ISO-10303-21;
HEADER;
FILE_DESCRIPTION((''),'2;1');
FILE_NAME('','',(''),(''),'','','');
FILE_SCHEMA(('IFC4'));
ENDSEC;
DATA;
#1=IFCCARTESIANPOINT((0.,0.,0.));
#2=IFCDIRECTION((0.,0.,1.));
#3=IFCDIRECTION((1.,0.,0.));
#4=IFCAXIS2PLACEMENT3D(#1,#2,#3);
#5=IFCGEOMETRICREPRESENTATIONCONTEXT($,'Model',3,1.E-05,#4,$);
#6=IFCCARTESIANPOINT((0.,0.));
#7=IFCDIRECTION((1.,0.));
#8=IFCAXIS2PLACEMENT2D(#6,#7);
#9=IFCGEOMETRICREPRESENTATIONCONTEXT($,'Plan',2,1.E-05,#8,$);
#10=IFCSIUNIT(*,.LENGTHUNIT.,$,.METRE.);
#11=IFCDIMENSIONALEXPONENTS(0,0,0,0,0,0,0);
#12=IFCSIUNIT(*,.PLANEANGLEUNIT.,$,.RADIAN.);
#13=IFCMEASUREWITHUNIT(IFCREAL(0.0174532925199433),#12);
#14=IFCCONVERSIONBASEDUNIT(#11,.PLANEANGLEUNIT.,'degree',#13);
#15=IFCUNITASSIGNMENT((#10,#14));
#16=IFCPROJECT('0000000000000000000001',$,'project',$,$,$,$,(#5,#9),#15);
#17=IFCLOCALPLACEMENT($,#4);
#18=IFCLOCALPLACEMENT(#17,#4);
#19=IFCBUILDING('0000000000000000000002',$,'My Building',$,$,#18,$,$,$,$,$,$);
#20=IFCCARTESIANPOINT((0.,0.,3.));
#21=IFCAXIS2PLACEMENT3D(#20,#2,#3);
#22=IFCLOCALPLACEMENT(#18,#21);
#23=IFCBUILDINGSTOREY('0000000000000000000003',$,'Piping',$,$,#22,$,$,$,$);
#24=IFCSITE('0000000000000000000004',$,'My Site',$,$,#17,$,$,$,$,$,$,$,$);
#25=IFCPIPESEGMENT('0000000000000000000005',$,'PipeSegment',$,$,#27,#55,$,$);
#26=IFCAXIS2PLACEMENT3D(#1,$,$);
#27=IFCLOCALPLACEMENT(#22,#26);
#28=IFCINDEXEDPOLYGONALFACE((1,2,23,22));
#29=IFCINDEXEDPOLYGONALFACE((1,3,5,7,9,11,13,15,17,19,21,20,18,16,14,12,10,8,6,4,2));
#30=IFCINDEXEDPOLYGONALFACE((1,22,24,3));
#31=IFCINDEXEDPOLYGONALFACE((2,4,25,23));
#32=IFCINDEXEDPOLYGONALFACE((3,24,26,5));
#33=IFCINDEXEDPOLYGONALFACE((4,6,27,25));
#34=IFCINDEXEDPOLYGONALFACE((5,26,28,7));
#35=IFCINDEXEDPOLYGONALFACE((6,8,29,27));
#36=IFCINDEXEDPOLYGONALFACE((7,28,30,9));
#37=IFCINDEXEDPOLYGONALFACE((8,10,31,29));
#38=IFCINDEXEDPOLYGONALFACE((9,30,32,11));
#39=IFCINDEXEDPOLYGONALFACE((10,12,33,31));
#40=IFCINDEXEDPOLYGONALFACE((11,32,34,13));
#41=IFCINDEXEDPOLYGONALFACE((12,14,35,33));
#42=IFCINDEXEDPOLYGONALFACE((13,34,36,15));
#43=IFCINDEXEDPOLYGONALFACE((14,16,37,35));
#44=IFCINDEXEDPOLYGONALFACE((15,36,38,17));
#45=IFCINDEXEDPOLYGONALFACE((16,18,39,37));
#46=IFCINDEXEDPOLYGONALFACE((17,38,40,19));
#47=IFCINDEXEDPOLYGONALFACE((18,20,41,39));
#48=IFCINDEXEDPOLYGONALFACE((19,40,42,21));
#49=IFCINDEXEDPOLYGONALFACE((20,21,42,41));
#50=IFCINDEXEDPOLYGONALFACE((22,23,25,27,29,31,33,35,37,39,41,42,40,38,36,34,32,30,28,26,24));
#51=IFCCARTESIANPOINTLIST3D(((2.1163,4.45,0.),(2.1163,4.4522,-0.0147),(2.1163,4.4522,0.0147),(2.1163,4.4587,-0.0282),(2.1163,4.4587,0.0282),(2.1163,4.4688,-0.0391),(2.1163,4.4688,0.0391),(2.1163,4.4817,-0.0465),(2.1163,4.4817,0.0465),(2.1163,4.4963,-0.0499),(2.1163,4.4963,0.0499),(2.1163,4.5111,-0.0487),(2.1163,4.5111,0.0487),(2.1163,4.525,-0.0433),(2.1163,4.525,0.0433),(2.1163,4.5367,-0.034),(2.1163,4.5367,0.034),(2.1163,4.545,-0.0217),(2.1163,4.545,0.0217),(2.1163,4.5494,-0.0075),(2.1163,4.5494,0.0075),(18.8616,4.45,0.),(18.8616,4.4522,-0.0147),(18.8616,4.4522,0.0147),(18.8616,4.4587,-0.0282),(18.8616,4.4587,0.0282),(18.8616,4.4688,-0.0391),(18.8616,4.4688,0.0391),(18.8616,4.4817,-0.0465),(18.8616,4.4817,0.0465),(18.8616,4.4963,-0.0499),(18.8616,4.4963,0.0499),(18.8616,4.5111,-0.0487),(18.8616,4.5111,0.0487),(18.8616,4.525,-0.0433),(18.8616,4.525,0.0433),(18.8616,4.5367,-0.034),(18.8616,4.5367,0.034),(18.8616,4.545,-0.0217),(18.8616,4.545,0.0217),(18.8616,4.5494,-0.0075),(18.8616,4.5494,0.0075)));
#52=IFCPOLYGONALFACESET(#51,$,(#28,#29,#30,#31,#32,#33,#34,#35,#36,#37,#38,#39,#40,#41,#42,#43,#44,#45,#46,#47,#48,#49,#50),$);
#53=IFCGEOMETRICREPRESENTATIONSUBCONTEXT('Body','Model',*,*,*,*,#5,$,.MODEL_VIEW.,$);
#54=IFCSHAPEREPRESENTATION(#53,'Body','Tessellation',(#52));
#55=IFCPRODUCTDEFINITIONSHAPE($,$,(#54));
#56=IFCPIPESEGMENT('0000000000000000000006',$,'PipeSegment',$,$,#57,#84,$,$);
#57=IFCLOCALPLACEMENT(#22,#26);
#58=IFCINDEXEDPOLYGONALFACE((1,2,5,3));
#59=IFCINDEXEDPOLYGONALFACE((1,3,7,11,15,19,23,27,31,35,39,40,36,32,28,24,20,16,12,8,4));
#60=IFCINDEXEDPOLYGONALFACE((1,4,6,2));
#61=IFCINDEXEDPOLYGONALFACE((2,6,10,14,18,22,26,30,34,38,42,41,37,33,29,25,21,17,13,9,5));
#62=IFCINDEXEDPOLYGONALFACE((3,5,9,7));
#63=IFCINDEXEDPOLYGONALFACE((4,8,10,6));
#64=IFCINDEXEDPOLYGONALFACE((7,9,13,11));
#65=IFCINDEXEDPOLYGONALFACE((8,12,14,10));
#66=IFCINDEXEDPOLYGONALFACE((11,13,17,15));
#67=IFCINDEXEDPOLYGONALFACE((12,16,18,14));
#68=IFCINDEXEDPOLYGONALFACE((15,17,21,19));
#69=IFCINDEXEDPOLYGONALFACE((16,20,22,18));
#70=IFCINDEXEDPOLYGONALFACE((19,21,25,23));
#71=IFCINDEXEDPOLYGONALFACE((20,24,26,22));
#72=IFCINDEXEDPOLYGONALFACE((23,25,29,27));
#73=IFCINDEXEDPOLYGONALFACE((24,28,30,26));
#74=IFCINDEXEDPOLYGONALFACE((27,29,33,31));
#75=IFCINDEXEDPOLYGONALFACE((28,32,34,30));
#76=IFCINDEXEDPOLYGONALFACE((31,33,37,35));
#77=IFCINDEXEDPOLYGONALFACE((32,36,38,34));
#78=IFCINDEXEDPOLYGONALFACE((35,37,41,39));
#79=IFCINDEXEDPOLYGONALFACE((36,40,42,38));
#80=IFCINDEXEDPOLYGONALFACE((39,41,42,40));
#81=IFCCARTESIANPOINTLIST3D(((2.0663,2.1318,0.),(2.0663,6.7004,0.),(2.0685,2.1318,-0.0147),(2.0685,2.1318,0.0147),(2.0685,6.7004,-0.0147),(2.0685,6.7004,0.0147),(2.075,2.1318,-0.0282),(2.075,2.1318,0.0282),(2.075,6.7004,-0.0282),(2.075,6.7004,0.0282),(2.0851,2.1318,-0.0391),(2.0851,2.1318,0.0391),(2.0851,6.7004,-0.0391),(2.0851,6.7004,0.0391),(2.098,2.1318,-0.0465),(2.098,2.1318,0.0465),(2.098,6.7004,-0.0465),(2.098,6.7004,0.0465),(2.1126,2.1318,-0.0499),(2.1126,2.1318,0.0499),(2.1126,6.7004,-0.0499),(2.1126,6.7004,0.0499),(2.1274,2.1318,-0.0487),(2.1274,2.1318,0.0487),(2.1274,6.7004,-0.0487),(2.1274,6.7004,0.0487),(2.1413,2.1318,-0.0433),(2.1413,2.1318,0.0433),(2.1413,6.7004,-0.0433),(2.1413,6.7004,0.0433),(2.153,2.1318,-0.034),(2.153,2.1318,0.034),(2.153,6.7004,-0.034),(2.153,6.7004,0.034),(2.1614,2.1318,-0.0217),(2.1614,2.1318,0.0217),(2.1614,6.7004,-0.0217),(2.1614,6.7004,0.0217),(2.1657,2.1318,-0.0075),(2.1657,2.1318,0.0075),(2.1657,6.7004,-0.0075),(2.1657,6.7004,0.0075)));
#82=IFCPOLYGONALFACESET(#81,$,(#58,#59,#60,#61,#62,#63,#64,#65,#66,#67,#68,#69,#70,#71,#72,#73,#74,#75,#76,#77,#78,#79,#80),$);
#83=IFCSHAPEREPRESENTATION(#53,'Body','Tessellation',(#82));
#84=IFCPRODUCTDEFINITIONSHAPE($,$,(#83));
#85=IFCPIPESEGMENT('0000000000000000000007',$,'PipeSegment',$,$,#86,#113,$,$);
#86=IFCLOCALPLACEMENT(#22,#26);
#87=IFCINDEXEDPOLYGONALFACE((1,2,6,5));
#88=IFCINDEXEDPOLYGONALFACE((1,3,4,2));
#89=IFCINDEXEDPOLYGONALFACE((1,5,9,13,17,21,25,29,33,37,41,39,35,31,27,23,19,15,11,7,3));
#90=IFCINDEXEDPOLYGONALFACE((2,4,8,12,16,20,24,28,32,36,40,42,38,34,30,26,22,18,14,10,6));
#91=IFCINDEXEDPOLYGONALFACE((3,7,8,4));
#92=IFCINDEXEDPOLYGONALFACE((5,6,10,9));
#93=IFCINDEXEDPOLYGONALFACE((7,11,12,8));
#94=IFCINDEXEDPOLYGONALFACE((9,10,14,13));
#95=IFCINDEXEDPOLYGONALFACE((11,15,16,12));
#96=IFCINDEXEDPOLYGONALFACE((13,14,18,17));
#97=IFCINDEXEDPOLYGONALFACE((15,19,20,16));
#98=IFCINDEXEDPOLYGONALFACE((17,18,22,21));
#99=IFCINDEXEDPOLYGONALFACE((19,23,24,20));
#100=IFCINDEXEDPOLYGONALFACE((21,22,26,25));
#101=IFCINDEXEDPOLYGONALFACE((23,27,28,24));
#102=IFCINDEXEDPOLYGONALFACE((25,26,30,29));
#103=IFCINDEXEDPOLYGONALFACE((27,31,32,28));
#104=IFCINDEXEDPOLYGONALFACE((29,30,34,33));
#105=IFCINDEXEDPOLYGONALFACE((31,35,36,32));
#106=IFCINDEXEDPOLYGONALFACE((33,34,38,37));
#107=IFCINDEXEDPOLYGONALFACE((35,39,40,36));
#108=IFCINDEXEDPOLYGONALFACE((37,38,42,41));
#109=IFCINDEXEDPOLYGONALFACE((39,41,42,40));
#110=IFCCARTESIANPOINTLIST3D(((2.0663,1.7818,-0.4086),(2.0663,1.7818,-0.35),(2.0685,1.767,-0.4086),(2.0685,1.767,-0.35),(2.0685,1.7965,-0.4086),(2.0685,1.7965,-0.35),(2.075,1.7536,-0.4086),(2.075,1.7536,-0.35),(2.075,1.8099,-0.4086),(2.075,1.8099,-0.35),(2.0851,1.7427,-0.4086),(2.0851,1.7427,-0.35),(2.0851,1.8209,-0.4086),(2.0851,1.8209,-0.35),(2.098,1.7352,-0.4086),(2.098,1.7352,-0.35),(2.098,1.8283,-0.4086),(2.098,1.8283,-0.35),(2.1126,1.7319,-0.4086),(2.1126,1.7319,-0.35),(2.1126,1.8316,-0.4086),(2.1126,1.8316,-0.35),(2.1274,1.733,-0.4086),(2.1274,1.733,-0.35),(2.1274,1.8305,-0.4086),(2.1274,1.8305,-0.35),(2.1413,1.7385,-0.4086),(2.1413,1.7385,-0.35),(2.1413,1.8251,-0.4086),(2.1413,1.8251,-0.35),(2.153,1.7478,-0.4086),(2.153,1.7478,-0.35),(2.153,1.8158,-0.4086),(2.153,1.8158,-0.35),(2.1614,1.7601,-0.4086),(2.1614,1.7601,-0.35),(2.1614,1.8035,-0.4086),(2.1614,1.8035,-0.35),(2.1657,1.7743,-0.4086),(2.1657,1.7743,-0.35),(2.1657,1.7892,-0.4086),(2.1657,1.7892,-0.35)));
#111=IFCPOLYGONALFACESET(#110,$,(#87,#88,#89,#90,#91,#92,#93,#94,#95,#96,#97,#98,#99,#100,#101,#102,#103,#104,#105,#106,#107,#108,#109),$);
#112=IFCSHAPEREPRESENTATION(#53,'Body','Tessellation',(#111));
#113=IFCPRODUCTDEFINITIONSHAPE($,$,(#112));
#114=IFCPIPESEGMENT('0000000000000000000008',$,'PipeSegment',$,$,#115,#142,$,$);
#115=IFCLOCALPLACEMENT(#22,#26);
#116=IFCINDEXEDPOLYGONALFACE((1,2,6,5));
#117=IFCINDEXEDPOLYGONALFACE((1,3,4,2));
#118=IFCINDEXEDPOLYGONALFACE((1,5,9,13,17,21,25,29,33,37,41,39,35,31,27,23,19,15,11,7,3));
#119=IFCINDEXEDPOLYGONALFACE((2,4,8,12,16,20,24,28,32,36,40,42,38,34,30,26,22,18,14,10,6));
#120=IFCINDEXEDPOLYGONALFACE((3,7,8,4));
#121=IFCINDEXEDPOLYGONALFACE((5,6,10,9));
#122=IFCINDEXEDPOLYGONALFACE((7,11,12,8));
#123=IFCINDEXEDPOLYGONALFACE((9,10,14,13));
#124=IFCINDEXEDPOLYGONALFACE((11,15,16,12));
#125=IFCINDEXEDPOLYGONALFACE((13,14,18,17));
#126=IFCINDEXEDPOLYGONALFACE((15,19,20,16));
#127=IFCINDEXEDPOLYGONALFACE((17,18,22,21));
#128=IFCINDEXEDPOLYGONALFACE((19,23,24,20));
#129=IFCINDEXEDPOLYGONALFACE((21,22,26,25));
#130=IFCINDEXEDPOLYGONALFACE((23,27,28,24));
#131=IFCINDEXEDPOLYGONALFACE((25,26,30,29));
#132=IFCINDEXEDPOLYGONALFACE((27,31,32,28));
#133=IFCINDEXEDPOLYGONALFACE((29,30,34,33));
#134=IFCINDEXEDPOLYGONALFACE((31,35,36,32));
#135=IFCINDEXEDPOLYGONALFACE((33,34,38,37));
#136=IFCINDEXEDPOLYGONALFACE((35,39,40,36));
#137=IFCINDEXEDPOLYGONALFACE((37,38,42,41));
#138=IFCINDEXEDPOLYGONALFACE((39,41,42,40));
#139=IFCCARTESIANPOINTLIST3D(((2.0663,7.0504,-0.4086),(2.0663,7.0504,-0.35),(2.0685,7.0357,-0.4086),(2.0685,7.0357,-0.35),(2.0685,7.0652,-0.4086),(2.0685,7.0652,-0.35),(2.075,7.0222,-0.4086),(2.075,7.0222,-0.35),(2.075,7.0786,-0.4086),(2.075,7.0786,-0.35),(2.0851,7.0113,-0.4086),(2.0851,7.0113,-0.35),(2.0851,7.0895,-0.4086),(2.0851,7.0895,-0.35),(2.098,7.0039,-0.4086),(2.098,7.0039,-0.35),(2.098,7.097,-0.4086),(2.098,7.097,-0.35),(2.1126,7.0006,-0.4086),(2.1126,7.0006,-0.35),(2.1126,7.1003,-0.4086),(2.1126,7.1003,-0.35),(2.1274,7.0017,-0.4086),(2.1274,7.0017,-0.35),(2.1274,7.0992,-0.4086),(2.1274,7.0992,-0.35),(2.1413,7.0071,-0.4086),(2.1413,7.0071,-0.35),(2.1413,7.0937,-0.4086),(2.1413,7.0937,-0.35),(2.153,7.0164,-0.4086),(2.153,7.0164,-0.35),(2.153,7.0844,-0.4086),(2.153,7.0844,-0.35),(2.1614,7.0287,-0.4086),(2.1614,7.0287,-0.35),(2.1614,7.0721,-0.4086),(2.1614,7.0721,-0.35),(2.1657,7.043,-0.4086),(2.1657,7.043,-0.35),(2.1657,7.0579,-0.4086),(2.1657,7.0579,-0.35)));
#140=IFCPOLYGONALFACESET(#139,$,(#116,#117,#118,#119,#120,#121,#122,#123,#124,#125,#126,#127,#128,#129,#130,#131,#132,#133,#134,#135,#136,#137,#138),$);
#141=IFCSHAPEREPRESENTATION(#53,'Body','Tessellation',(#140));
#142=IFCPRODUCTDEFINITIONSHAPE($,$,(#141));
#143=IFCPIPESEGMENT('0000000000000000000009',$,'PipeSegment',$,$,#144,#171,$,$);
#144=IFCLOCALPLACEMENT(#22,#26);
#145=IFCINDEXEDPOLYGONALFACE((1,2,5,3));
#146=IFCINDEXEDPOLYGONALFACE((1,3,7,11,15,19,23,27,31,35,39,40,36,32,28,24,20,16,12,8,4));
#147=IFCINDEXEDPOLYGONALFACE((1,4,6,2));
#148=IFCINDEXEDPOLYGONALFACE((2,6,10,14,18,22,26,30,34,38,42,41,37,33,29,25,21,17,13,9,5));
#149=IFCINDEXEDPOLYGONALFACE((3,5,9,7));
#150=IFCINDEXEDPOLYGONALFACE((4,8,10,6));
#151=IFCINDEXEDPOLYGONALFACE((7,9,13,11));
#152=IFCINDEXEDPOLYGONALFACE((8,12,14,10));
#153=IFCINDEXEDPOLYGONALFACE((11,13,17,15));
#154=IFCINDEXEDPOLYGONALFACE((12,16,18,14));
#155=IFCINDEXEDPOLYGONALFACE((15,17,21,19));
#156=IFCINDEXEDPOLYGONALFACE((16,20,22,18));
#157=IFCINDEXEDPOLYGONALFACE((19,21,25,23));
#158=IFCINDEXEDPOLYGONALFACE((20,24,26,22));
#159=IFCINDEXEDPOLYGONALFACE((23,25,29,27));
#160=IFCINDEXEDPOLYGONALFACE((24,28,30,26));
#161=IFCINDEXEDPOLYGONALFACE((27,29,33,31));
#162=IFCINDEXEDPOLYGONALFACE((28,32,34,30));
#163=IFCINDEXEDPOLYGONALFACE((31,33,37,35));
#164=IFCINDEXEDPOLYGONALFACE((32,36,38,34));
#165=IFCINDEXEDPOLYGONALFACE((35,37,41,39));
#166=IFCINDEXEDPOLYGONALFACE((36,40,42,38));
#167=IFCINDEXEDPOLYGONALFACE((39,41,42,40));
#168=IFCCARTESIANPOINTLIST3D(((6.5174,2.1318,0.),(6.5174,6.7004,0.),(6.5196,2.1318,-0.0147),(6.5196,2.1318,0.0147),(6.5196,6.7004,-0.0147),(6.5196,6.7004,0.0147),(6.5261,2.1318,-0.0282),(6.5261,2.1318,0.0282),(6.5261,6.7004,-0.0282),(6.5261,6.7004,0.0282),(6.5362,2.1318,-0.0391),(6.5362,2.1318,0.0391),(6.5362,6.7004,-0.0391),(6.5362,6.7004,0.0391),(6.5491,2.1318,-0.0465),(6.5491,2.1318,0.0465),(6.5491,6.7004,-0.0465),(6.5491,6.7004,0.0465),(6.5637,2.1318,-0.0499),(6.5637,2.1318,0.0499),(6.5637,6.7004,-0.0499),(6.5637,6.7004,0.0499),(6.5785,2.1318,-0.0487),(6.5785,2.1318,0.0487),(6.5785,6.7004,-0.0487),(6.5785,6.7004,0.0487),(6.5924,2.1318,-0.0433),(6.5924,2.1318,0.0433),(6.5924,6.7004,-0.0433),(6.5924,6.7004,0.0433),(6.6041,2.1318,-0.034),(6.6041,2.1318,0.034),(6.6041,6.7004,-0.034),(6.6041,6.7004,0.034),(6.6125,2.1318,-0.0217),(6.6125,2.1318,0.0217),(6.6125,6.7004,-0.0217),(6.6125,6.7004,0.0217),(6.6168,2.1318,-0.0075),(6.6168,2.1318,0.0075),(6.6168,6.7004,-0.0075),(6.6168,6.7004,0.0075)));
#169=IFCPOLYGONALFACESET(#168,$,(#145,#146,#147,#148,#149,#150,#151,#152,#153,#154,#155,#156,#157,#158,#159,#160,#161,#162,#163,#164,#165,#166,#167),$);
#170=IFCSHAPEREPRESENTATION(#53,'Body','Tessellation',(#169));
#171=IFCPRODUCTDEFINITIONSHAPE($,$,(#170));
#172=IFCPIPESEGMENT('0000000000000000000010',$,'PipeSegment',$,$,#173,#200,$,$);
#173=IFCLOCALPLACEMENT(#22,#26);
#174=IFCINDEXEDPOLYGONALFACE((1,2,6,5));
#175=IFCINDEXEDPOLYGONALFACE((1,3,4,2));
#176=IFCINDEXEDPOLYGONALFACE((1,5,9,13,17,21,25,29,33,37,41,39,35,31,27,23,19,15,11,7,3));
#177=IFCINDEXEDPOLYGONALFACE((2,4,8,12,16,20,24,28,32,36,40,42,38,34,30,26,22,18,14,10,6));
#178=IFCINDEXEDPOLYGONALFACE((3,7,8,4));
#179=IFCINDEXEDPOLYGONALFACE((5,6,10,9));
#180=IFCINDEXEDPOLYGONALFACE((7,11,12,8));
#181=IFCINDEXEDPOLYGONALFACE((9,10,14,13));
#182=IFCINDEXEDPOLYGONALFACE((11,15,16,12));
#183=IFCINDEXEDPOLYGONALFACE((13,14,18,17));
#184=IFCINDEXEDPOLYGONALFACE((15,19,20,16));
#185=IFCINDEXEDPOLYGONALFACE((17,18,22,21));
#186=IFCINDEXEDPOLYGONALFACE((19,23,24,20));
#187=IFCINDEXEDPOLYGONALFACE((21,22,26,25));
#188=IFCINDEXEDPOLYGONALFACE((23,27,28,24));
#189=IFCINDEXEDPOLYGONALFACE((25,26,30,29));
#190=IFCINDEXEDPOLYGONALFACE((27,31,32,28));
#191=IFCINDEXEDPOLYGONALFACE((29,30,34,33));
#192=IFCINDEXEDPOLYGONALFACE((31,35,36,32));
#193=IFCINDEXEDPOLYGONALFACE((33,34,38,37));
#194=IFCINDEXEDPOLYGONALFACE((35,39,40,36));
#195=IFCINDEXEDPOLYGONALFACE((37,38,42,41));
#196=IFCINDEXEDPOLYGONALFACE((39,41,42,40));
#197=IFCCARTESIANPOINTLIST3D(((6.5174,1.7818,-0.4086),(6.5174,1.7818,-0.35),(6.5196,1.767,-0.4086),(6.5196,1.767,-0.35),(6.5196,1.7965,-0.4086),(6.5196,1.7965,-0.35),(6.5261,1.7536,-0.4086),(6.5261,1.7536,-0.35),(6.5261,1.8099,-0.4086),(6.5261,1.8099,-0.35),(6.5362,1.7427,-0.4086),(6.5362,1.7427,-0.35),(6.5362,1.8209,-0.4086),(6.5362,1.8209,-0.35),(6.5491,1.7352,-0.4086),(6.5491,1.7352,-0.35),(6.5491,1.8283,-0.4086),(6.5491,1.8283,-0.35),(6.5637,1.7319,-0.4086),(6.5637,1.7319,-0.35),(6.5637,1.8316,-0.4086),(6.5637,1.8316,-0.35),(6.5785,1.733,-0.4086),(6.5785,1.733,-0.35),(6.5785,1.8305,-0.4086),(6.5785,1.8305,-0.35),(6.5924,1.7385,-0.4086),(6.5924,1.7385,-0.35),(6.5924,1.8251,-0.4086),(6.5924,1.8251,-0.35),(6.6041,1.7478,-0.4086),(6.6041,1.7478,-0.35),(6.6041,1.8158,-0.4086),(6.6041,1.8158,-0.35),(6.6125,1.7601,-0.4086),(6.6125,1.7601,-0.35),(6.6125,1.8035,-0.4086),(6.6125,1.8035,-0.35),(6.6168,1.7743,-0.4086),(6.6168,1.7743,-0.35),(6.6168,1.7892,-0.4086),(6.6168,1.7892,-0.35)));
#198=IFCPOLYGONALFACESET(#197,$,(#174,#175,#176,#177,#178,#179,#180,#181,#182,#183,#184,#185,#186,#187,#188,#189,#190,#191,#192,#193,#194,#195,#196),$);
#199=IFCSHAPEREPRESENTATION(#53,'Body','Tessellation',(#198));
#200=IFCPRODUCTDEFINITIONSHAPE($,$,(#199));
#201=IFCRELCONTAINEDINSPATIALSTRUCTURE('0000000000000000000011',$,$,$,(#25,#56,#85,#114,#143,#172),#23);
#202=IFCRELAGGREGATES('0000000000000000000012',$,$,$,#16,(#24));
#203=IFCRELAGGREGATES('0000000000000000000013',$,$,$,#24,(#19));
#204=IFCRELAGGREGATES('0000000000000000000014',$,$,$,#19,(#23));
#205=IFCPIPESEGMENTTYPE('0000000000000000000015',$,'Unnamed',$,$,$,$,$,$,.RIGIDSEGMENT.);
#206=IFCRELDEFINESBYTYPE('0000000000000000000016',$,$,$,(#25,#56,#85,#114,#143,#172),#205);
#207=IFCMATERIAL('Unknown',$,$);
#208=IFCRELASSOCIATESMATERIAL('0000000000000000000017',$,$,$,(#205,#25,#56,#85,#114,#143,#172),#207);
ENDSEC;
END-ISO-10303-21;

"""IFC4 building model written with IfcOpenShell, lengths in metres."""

from ifc_helpers import new_model, entity, si_unit, converted_unit, frame, origin_with_axes, origin_2d_with_axis, place, context, subcontext, project, spatial, circle, extrude, material, material_profile, profile_set, profile_usage, type_object, element, save


model = new_model("IFC4")

# Units and contexts
model_context = context("Model", 3, precision=1e-05, world=origin_with_axes())
plan_context = context("Plan", 2, precision=1e-05, world=origin_2d_with_axis())
body_context = subcontext(model_context, "Body", "Model", "MODEL_VIEW")
ifc_project = project(units=[si_unit("LENGTHUNIT", "METRE"), converted_unit("PLANEANGLEUNIT", "degree", entity("IfcReal", 0.0174532925199433), si_unit("PLANEANGLEUNIT", "RADIAN"), dimensions=[0, 0, 0, 0, 0, 0, 0])], contexts=[model_context, plan_context])

# Site, building, storey
site_placement = place(None, origin_with_axes())
site = spatial("IfcSite", under=ifc_project, at=site_placement, Name="My Site")
building_placement = place(site_placement, origin_with_axes())
building = spatial("IfcBuilding", under=site, at=building_placement, Name="My Building")
storey_placement = place(building_placement, frame((0.0, 0.0, 3.0), z_axis=(0.0, 0.0, 1.0), x_axis=(1.0, 0.0, 0.0)))
storey = spatial("IfcBuildingStorey", under=building, at=storey_placement, Name="Piping")

# Pipe segments
ifc_material = material(Name="Unknown")
ifc_material_profile = material_profile(ifc_material, circle(Radius=0.05))
ifc_profile_set = profile_set([ifc_material_profile])
ifc_profile_usage_1 = profile_usage(ifc_profile_set, cardinal=5)
pipe_segment_type = type_object("IfcPipeSegmentType", Name="Unnamed", PredefinedType="RIGIDSEGMENT", material=ifc_profile_set)
pipe_segment_1_placement = place(storey_placement, frame((18.8616, 4.5, 0.0), z_axis=(-1.0, 0.0, 0.0), x_axis=(0.0, -1.0, 0.0)))
element("IfcPipeSegment", 1, at=pipe_segment_1_placement, inside=storey, type_object=pipe_segment_type, material=ifc_profile_usage_1, Name="PipeSegment", context=body_context, shape_type="SweptSolid", body=[
    extrude(circle(Radius=0.05), origin_with_axes(), (0.0, 0.0, 1.0), 16.7453),
])
ifc_profile_usage_2 = profile_usage(ifc_profile_set, cardinal=5)
pipe_segment_2_placement = place(storey_placement, frame((2.1163, 2.1318, 0.0), z_axis=(0.0, 1.0, 0.0), x_axis=(-1.0, 0.0, 0.0)))
element("IfcPipeSegment", 2, at=pipe_segment_2_placement, inside=storey, type_object=pipe_segment_type, material=ifc_profile_usage_2, Name="PipeSegment", context=body_context, shape_type="SweptSolid", body=[
    extrude(circle(Radius=0.05), origin_with_axes(), (0.0, 0.0, 1.0), 4.5686),
])
ifc_profile_usage_3 = profile_usage(ifc_profile_set, cardinal=5)
pipe_segment_3_placement = place(storey_placement, frame((2.1163, 1.7818, -0.35), z_axis=(0.0, 0.0, -1.0), x_axis=(-1.0, 0.0, 0.0)))
element("IfcPipeSegment", 3, at=pipe_segment_3_placement, inside=storey, type_object=pipe_segment_type, material=ifc_profile_usage_3, Name="PipeSegment", context=body_context, shape_type="SweptSolid", body=[
    extrude(circle(Radius=0.05), origin_with_axes(), (0.0, 0.0, 1.0), 0.0586),
])
ifc_profile_usage_4 = profile_usage(ifc_profile_set, cardinal=5)
pipe_segment_4_placement = place(storey_placement, frame((2.1163, 7.0504, -0.35), z_axis=(0.0, 0.0, -1.0), x_axis=(-1.0, 0.0, 0.0)))
element("IfcPipeSegment", 4, at=pipe_segment_4_placement, inside=storey, type_object=pipe_segment_type, material=ifc_profile_usage_4, Name="PipeSegment", context=body_context, shape_type="SweptSolid", body=[
    extrude(circle(Radius=0.05), origin_with_axes(), (0.0, 0.0, 1.0), 0.0586),
])
ifc_profile_usage_5 = profile_usage(ifc_profile_set, cardinal=5)
pipe_segment_5_placement = place(storey_placement, frame((6.5674, 2.1318, 0.0), z_axis=(0.0, 1.0, 0.0), x_axis=(-1.0, 0.0, 0.0)))
element("IfcPipeSegment", 5, at=pipe_segment_5_placement, inside=storey, type_object=pipe_segment_type, material=ifc_profile_usage_5, Name="PipeSegment", context=body_context, shape_type="SweptSolid", body=[
    extrude(circle(Radius=0.05), origin_with_axes(), (0.0, 0.0, 1.0), 4.5686),
])
ifc_profile_usage_6 = profile_usage(ifc_profile_set, cardinal=5)
pipe_segment_6_placement = place(storey_placement, frame((6.5674, 1.7818, -0.35), z_axis=(0.0, 0.0, -1.0), x_axis=(-1.0, 0.0, 0.0)))
element("IfcPipeSegment", 6, at=pipe_segment_6_placement, inside=storey, type_object=pipe_segment_type, material=ifc_profile_usage_6, Name="PipeSegment", context=body_context, shape_type="SweptSolid", body=[
    extrude(circle(Radius=0.05), origin_with_axes(), (0.0, 0.0, 1.0), 0.0586),
])

save(model, "model.ifc")
